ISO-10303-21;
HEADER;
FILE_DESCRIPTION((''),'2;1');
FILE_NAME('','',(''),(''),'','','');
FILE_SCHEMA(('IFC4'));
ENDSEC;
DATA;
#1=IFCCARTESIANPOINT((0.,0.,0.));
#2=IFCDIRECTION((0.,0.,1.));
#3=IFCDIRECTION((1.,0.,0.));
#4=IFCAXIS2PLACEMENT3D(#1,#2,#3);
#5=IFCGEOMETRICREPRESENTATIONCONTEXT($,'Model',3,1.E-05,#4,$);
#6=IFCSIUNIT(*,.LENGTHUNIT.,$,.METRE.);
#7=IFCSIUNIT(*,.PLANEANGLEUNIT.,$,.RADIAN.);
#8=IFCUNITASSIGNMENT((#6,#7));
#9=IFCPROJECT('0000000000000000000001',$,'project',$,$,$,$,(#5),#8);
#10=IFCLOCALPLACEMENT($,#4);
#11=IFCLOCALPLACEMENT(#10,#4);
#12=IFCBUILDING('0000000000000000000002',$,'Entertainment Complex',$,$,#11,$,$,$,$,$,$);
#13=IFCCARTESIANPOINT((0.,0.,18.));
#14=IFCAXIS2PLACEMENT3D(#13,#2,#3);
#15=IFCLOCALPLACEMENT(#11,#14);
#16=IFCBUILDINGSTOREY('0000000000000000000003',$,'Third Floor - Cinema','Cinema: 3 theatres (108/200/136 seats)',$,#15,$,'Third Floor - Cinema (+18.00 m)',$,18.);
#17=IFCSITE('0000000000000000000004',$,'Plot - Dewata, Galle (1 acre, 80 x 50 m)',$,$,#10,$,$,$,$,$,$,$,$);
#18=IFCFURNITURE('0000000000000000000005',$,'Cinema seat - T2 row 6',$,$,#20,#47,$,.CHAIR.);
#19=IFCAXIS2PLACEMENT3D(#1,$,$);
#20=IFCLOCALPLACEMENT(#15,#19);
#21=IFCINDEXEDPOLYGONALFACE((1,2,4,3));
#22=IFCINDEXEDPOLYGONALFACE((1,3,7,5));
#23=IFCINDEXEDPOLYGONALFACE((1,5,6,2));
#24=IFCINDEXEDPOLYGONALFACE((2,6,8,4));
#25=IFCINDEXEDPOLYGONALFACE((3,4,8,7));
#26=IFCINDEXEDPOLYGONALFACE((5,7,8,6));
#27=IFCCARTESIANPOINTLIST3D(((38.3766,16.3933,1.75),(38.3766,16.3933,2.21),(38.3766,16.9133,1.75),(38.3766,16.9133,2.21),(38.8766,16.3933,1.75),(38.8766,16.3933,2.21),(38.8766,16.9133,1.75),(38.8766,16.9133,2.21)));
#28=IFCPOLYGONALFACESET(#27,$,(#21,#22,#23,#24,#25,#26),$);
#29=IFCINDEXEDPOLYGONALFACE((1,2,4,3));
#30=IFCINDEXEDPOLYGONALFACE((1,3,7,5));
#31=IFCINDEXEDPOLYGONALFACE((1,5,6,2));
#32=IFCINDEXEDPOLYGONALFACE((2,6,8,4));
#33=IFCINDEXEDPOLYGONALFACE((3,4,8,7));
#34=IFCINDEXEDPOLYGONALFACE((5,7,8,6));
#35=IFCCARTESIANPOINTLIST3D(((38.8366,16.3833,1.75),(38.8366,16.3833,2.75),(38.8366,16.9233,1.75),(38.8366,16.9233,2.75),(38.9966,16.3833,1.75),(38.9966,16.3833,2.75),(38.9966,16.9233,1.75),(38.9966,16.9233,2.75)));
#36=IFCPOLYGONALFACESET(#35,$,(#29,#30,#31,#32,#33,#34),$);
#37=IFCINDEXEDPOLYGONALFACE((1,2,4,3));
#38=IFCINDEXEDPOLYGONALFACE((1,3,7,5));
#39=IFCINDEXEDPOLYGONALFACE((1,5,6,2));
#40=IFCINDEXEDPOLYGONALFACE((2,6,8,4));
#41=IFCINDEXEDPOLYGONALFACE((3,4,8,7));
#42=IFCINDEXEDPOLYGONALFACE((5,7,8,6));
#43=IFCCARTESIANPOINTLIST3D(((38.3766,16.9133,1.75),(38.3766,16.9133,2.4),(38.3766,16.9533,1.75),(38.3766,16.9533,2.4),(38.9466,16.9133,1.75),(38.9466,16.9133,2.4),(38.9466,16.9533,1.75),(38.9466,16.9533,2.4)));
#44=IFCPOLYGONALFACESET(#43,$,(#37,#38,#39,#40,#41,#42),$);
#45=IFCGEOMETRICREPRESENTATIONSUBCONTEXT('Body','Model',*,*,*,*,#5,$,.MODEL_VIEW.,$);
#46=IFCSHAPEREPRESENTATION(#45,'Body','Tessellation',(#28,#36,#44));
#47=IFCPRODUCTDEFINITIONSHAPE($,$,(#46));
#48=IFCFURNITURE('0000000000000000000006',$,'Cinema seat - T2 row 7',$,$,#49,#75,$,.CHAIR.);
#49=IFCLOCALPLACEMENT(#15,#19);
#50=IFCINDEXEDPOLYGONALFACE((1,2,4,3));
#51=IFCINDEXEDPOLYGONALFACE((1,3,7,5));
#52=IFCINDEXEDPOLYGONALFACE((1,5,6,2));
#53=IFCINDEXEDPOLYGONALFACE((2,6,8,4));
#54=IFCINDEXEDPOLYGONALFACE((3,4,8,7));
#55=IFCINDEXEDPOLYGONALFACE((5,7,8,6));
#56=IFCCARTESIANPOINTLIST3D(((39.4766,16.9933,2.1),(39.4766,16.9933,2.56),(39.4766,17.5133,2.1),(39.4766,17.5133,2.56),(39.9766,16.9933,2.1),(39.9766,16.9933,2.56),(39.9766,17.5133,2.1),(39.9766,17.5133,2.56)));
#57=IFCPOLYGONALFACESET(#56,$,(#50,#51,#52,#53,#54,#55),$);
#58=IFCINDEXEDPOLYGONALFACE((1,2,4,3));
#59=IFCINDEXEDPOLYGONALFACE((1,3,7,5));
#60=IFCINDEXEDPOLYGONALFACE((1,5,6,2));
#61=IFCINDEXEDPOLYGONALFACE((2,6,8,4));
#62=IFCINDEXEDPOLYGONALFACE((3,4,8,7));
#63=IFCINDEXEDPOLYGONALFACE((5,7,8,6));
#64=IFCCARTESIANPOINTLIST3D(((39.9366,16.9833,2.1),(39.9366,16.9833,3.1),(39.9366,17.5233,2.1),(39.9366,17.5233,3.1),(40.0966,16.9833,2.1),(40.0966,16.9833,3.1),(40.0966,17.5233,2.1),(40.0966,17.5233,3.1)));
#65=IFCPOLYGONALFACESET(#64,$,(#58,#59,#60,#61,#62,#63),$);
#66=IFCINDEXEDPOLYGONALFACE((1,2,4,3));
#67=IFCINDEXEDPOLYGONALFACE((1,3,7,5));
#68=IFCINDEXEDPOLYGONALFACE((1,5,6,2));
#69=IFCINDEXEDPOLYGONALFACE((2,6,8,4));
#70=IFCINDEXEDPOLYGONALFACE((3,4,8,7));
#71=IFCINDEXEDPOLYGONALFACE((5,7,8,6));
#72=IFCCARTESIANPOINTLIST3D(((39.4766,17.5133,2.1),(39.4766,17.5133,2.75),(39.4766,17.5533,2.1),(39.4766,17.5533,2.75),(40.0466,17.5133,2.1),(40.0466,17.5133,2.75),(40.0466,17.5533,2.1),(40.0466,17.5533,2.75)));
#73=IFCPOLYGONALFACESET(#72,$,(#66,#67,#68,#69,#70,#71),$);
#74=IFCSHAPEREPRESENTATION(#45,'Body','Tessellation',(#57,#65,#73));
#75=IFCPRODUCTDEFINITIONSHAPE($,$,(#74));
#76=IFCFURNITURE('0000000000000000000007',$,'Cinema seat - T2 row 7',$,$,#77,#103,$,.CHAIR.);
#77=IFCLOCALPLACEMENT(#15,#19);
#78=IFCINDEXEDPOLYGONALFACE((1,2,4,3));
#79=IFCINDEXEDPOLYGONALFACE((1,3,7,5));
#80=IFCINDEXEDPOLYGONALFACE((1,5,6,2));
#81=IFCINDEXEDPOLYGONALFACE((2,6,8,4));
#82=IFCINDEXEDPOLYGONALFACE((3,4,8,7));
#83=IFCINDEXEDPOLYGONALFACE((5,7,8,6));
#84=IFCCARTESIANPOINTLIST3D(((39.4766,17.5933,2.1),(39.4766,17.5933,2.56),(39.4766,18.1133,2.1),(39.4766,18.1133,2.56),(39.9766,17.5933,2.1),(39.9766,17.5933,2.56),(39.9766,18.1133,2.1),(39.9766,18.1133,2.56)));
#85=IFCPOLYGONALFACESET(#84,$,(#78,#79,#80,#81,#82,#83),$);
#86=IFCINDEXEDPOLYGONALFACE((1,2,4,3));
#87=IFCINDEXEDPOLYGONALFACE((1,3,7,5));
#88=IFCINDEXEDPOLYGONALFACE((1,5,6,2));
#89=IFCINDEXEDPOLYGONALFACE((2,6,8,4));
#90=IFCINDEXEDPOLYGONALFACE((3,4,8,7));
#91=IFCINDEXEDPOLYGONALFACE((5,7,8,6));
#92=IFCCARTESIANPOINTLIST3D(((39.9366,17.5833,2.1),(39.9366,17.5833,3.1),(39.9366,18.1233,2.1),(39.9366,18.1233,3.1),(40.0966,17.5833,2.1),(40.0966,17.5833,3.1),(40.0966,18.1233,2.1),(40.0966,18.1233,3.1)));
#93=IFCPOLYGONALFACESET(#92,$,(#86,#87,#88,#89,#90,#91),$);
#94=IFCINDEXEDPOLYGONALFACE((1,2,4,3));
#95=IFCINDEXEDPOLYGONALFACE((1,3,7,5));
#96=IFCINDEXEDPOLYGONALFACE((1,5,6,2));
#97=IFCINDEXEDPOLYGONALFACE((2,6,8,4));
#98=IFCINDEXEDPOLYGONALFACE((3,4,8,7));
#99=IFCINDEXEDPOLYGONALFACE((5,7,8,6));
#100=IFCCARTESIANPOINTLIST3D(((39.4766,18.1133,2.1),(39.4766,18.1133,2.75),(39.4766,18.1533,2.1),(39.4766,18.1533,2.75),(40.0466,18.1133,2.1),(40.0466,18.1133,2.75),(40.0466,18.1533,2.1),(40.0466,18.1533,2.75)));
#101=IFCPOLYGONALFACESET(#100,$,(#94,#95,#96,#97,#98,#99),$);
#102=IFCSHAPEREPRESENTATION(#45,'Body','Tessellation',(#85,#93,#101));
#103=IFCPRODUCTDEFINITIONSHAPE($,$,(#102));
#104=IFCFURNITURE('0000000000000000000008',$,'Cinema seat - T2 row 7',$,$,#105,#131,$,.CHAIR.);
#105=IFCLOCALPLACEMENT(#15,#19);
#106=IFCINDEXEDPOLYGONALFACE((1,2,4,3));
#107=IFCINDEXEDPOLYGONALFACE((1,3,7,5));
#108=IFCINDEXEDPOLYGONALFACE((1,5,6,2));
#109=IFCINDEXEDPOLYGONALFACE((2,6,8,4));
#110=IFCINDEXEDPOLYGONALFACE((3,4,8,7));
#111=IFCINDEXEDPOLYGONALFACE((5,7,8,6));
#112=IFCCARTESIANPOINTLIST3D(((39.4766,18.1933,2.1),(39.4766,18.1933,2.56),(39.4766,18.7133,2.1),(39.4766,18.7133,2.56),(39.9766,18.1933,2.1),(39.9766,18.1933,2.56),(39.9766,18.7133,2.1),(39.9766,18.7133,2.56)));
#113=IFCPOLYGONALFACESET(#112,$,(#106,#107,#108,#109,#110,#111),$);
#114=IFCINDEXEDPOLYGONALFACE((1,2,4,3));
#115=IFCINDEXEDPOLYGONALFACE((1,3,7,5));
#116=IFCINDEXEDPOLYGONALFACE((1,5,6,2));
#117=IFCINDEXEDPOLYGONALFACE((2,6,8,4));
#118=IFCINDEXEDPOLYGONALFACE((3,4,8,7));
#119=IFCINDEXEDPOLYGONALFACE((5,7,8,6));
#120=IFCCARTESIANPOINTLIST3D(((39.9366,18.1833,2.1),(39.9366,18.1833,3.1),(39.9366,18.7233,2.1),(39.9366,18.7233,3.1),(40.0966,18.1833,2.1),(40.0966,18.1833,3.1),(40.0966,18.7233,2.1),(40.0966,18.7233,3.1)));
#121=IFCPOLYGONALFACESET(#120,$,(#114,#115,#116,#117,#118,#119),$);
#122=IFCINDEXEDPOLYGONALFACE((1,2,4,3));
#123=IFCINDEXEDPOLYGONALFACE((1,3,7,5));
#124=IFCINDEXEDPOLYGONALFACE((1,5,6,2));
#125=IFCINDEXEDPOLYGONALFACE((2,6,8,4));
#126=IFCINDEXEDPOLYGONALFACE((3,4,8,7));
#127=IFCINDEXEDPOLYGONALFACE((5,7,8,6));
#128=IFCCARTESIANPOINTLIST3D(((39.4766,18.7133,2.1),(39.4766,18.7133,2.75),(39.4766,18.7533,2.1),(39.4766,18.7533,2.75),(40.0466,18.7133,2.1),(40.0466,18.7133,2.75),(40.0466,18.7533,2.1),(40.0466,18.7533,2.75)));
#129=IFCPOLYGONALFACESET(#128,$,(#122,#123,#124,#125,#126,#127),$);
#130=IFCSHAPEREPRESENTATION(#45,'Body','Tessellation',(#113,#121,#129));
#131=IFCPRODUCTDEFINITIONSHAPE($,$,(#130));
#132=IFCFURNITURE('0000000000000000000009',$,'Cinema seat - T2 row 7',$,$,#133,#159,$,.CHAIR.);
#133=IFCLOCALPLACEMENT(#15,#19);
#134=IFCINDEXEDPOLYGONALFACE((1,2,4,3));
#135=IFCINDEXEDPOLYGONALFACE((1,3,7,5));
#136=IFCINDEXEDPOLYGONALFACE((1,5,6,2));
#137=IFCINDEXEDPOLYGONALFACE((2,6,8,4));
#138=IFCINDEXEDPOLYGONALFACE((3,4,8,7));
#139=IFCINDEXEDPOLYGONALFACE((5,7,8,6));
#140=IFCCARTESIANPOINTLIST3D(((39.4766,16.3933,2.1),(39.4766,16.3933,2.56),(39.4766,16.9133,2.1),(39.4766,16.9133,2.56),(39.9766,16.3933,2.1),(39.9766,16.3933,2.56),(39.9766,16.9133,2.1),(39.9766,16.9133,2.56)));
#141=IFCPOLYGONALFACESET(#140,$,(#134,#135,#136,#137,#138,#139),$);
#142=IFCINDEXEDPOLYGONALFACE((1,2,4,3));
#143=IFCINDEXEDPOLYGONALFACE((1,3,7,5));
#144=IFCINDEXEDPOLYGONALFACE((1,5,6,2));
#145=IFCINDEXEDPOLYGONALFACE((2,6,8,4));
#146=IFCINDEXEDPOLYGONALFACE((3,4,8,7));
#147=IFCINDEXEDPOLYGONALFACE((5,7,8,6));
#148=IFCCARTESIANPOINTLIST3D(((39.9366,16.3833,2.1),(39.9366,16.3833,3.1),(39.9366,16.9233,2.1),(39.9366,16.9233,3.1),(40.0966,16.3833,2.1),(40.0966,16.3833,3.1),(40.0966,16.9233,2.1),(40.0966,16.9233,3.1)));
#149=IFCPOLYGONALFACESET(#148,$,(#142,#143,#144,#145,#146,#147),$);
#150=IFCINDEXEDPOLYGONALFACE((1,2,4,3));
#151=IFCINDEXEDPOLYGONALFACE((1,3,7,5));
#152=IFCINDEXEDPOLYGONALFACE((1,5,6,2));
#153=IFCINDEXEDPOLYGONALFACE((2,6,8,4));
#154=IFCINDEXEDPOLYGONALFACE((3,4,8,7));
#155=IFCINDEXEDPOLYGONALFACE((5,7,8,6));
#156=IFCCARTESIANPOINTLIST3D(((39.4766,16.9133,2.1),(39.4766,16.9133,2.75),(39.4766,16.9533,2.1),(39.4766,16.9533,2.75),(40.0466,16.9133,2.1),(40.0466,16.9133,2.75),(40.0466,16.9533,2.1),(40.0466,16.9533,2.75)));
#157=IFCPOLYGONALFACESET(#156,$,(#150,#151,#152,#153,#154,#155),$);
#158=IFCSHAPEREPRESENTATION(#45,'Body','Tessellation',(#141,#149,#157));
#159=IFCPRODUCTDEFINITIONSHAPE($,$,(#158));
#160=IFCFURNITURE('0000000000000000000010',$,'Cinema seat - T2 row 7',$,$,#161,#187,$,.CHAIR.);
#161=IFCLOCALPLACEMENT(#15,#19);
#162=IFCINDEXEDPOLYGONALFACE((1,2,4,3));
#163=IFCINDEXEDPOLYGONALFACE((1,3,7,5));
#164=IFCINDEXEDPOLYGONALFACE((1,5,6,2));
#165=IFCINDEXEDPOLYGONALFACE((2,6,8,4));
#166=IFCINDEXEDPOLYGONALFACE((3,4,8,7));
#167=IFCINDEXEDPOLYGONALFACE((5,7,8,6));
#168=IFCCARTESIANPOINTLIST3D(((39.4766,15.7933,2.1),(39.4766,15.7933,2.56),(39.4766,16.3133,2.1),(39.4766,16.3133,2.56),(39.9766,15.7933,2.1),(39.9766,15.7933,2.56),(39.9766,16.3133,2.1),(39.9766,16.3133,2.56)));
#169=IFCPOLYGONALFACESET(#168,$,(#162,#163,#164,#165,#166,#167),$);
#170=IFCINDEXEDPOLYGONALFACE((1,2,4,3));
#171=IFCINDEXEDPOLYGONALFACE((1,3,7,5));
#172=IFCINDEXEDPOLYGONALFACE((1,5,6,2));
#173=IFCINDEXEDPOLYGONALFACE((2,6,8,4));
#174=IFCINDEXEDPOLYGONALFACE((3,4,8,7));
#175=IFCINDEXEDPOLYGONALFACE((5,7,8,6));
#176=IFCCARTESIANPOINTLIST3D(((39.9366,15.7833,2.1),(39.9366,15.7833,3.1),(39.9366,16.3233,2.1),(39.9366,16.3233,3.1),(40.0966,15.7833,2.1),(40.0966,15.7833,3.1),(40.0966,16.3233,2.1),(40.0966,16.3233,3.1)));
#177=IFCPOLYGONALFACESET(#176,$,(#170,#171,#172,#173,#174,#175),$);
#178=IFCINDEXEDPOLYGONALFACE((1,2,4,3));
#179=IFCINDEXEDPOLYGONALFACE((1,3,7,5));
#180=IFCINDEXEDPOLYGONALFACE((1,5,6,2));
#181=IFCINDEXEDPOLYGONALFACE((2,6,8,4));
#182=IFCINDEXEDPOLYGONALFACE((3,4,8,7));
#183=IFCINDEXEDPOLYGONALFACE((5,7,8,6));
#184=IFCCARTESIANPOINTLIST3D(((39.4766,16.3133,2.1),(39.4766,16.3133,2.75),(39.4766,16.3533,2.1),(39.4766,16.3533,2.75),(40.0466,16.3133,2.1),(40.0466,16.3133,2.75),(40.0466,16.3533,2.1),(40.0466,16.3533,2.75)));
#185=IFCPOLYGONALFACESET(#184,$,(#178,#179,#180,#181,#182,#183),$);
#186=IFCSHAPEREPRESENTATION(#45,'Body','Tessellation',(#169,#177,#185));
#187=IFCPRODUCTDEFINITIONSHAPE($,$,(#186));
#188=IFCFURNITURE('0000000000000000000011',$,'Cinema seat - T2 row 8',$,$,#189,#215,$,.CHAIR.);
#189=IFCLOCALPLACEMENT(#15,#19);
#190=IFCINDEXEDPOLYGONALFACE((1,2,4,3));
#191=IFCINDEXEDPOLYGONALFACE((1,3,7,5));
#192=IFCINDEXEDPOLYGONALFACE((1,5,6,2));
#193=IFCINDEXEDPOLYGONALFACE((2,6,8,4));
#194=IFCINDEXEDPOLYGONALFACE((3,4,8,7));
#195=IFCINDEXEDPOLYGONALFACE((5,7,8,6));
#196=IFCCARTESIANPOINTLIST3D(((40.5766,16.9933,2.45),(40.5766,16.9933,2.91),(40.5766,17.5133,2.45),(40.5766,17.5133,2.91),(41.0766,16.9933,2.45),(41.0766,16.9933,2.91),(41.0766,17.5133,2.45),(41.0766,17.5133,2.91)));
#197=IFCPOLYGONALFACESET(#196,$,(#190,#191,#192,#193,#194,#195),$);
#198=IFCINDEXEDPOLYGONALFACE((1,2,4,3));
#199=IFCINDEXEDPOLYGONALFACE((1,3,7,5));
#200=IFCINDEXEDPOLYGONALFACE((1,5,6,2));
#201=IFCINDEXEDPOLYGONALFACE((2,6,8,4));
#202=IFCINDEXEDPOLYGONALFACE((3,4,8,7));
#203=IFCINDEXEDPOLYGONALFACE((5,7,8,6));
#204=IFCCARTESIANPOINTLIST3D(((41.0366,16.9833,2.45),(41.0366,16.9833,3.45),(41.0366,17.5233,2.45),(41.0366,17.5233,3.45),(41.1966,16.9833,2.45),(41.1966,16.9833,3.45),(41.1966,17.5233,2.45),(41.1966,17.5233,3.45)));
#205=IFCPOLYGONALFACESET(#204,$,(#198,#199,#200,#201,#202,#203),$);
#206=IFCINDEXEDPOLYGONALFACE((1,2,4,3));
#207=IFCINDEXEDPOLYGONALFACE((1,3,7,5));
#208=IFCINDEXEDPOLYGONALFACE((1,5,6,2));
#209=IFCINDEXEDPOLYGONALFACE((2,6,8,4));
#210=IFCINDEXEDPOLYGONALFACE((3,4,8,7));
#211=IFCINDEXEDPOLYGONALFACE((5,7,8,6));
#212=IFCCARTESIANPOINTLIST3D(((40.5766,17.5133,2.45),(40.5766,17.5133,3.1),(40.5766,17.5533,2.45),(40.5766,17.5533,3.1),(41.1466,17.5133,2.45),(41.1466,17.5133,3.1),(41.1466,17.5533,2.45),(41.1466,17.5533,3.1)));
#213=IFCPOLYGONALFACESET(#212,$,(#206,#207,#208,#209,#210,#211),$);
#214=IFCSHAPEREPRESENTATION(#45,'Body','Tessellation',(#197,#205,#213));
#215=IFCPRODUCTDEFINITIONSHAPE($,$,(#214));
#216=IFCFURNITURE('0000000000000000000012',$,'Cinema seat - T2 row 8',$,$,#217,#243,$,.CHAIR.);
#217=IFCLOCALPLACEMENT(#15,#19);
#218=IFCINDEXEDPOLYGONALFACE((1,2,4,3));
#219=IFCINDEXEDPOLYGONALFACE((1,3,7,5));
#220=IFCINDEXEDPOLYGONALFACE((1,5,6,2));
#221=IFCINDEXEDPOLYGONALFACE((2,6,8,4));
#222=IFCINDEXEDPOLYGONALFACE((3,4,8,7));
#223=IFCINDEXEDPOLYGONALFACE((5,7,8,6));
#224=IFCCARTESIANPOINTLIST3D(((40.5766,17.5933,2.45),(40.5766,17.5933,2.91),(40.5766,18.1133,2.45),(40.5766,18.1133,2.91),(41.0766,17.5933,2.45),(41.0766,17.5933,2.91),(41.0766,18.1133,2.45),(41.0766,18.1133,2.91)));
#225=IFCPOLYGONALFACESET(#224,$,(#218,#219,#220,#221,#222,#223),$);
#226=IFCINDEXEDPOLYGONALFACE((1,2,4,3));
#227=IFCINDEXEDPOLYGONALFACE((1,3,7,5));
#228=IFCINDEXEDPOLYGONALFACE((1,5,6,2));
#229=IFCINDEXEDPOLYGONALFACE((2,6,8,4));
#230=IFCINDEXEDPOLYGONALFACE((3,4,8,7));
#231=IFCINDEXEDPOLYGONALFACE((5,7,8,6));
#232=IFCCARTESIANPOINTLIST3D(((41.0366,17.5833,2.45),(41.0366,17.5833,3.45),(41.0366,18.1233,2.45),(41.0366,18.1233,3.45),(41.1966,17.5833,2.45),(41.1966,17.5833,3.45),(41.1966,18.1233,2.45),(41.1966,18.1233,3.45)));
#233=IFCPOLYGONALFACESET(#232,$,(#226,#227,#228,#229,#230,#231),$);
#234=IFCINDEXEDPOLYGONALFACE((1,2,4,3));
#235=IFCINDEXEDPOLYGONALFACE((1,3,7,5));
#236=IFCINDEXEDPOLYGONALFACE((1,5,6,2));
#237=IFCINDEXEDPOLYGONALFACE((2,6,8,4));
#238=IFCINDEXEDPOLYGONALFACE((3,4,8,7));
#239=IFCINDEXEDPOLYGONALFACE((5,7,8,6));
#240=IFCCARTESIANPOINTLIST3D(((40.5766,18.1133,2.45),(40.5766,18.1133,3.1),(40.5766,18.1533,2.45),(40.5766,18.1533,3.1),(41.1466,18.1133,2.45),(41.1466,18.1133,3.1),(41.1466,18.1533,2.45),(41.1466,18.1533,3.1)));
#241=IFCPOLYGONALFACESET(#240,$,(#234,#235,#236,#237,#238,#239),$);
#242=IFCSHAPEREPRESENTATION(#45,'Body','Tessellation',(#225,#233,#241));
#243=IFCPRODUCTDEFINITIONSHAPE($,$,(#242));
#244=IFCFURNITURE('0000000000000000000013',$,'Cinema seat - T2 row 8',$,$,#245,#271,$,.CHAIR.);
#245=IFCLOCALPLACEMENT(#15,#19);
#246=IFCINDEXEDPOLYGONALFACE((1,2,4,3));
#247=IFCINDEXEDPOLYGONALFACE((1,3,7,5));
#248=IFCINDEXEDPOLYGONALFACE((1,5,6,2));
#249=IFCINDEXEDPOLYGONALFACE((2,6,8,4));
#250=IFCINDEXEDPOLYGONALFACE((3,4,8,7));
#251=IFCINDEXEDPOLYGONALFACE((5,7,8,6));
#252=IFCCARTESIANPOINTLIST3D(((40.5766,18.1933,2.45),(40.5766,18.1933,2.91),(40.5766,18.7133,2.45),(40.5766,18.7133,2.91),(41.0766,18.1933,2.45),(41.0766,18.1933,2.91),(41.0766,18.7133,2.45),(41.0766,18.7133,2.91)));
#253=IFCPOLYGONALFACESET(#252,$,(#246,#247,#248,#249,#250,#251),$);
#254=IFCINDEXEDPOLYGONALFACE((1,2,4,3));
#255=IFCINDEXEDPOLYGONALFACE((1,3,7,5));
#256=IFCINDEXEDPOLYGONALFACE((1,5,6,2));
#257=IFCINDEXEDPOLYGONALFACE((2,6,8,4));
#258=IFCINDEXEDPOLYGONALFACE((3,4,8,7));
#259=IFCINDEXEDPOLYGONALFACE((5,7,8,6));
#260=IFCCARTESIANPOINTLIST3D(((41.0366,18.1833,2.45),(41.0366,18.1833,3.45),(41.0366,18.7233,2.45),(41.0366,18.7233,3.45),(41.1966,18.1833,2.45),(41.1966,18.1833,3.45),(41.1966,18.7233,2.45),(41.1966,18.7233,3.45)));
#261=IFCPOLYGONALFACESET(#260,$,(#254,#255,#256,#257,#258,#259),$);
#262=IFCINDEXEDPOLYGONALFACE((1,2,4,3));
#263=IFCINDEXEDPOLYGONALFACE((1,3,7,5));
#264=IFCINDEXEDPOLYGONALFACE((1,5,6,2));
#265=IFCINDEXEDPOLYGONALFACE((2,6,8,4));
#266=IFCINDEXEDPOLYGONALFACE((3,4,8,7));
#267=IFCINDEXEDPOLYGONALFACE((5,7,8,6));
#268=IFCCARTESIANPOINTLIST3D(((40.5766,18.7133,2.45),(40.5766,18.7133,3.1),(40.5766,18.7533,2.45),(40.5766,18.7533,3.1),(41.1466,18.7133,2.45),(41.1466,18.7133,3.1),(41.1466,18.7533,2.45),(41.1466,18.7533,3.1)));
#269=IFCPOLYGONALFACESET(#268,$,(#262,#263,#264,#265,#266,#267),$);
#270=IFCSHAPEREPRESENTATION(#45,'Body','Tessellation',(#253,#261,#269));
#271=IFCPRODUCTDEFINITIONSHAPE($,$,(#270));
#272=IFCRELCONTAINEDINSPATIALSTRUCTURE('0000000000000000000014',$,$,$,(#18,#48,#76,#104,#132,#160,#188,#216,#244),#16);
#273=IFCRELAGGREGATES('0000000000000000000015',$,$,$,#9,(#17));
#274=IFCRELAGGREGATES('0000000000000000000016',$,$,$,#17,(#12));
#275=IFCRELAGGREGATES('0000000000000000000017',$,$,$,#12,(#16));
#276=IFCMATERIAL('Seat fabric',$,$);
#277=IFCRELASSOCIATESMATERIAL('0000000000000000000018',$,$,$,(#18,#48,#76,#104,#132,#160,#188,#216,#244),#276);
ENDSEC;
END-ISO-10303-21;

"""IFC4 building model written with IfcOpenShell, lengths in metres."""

from ifc_helpers import new_model, si_unit, frame, origin_with_axes, place, context, subcontext, project, spatial, polyline, outline, extrude, material, element, save


model = new_model("IFC4")

# Units and contexts
model_context = context("Model", 3, precision=1e-05, world=origin_with_axes())
body_context = subcontext(model_context, "Body", "Model", "MODEL_VIEW")
ifc_project = project(units=[si_unit("LENGTHUNIT", "METRE"), si_unit("PLANEANGLEUNIT", "RADIAN")], contexts=[model_context])

# Site, building, storey
site_placement = place(None, origin_with_axes())
site = spatial("IfcSite", under=ifc_project, at=site_placement, Name="Plot - Dewata, Galle (1 acre, 80 x 50 m)")
building_placement = place(site_placement, origin_with_axes())
building = spatial("IfcBuilding", under=site, at=building_placement, Name="Entertainment Complex")
storey_placement = place(building_placement, frame((0.0, 0.0, 18.0), z_axis=(0.0, 0.0, 1.0), x_axis=(1.0, 0.0, 0.0)))
storey = spatial("IfcBuildingStorey", under=building, at=storey_placement, Name="Third Floor - Cinema", Description="Cinema: 3 theatres (108/200/136 seats)", LongName="Third Floor - Cinema (+18.00 m)", Elevation=18.0)

# Furniture
ifc_material_1 = material(Name="Seat fabric")
for number, where, z_axis, x_axis, name in (
    (1, (38.9966, 16.6533, 1.75), (0.0, 0.0, 1.0), (1.0, 0.0, 0.0), "Cinema seat - T2 row 6"),
    (2, (40.0966, 17.2533, 2.1), (0.0, 0.0, 1.0), (1.0, 0.0, 0.0), "Cinema seat - T2 row 7"),
    (3, (40.0966, 17.8533, 2.1), (0.0, 0.0, 1.0), (1.0, 0.0, 0.0), "Cinema seat - T2 row 7"),
    (4, (40.0966, 18.4533, 2.1), (0.0, 0.0, 1.0), (1.0, 0.0, 0.0), "Cinema seat - T2 row 7"),
    (5, (40.0966, 16.6533, 2.1), (0.0, 0.0, 1.0), (1.0, 0.0, 0.0), "Cinema seat - T2 row 7"),
    (6, (40.0966, 16.0533, 2.1), (0.0, 0.0, 1.0), (1.0, 0.0, 0.0), "Cinema seat - T2 row 7"),
    (7, (41.1966, 17.2533, 2.45), (0.0, 0.0, 1.0), (1.0, 0.0, 0.0), "Cinema seat - T2 row 8"),
    (8, (41.1966, 17.8533, 2.45), (0.0, 0.0, 1.0), (1.0, 0.0, 0.0), "Cinema seat - T2 row 8"),
    (9, (41.1966, 18.4533, 2.45), (0.0, 0.0, 1.0), (1.0, 0.0, 0.0), "Cinema seat - T2 row 8"),
):
    element("IfcFurniture", number, at=place(storey_placement, frame(where, z_axis=z_axis, x_axis=x_axis)), inside=storey, material=ifc_material_1, Name=name, PredefinedType="CHAIR", context=body_context, shape_type="SweptSolid", body=[
        extrude(outline(polyline([(-0.62, -0.26), (-0.12, -0.26), (-0.12, 0.26), (-0.62, 0.26), (-0.62, -0.26)])), origin_with_axes(), (0.0, 0.0, 1.0), 0.46),
        extrude(outline(polyline([(-0.16, -0.27), (0.0, -0.27), (0.0, 0.27), (-0.16, 0.27), (-0.16, -0.27)])), origin_with_axes(), (0.0, 0.0, 1.0), 1.0),
        extrude(outline(polyline([(-0.62, 0.26), (-0.05, 0.26), (-0.05, 0.3), (-0.62, 0.3), (-0.62, 0.26)])), origin_with_axes(), (0.0, 0.0, 1.0), 0.65),
    ])

save(model, "model.ifc")
